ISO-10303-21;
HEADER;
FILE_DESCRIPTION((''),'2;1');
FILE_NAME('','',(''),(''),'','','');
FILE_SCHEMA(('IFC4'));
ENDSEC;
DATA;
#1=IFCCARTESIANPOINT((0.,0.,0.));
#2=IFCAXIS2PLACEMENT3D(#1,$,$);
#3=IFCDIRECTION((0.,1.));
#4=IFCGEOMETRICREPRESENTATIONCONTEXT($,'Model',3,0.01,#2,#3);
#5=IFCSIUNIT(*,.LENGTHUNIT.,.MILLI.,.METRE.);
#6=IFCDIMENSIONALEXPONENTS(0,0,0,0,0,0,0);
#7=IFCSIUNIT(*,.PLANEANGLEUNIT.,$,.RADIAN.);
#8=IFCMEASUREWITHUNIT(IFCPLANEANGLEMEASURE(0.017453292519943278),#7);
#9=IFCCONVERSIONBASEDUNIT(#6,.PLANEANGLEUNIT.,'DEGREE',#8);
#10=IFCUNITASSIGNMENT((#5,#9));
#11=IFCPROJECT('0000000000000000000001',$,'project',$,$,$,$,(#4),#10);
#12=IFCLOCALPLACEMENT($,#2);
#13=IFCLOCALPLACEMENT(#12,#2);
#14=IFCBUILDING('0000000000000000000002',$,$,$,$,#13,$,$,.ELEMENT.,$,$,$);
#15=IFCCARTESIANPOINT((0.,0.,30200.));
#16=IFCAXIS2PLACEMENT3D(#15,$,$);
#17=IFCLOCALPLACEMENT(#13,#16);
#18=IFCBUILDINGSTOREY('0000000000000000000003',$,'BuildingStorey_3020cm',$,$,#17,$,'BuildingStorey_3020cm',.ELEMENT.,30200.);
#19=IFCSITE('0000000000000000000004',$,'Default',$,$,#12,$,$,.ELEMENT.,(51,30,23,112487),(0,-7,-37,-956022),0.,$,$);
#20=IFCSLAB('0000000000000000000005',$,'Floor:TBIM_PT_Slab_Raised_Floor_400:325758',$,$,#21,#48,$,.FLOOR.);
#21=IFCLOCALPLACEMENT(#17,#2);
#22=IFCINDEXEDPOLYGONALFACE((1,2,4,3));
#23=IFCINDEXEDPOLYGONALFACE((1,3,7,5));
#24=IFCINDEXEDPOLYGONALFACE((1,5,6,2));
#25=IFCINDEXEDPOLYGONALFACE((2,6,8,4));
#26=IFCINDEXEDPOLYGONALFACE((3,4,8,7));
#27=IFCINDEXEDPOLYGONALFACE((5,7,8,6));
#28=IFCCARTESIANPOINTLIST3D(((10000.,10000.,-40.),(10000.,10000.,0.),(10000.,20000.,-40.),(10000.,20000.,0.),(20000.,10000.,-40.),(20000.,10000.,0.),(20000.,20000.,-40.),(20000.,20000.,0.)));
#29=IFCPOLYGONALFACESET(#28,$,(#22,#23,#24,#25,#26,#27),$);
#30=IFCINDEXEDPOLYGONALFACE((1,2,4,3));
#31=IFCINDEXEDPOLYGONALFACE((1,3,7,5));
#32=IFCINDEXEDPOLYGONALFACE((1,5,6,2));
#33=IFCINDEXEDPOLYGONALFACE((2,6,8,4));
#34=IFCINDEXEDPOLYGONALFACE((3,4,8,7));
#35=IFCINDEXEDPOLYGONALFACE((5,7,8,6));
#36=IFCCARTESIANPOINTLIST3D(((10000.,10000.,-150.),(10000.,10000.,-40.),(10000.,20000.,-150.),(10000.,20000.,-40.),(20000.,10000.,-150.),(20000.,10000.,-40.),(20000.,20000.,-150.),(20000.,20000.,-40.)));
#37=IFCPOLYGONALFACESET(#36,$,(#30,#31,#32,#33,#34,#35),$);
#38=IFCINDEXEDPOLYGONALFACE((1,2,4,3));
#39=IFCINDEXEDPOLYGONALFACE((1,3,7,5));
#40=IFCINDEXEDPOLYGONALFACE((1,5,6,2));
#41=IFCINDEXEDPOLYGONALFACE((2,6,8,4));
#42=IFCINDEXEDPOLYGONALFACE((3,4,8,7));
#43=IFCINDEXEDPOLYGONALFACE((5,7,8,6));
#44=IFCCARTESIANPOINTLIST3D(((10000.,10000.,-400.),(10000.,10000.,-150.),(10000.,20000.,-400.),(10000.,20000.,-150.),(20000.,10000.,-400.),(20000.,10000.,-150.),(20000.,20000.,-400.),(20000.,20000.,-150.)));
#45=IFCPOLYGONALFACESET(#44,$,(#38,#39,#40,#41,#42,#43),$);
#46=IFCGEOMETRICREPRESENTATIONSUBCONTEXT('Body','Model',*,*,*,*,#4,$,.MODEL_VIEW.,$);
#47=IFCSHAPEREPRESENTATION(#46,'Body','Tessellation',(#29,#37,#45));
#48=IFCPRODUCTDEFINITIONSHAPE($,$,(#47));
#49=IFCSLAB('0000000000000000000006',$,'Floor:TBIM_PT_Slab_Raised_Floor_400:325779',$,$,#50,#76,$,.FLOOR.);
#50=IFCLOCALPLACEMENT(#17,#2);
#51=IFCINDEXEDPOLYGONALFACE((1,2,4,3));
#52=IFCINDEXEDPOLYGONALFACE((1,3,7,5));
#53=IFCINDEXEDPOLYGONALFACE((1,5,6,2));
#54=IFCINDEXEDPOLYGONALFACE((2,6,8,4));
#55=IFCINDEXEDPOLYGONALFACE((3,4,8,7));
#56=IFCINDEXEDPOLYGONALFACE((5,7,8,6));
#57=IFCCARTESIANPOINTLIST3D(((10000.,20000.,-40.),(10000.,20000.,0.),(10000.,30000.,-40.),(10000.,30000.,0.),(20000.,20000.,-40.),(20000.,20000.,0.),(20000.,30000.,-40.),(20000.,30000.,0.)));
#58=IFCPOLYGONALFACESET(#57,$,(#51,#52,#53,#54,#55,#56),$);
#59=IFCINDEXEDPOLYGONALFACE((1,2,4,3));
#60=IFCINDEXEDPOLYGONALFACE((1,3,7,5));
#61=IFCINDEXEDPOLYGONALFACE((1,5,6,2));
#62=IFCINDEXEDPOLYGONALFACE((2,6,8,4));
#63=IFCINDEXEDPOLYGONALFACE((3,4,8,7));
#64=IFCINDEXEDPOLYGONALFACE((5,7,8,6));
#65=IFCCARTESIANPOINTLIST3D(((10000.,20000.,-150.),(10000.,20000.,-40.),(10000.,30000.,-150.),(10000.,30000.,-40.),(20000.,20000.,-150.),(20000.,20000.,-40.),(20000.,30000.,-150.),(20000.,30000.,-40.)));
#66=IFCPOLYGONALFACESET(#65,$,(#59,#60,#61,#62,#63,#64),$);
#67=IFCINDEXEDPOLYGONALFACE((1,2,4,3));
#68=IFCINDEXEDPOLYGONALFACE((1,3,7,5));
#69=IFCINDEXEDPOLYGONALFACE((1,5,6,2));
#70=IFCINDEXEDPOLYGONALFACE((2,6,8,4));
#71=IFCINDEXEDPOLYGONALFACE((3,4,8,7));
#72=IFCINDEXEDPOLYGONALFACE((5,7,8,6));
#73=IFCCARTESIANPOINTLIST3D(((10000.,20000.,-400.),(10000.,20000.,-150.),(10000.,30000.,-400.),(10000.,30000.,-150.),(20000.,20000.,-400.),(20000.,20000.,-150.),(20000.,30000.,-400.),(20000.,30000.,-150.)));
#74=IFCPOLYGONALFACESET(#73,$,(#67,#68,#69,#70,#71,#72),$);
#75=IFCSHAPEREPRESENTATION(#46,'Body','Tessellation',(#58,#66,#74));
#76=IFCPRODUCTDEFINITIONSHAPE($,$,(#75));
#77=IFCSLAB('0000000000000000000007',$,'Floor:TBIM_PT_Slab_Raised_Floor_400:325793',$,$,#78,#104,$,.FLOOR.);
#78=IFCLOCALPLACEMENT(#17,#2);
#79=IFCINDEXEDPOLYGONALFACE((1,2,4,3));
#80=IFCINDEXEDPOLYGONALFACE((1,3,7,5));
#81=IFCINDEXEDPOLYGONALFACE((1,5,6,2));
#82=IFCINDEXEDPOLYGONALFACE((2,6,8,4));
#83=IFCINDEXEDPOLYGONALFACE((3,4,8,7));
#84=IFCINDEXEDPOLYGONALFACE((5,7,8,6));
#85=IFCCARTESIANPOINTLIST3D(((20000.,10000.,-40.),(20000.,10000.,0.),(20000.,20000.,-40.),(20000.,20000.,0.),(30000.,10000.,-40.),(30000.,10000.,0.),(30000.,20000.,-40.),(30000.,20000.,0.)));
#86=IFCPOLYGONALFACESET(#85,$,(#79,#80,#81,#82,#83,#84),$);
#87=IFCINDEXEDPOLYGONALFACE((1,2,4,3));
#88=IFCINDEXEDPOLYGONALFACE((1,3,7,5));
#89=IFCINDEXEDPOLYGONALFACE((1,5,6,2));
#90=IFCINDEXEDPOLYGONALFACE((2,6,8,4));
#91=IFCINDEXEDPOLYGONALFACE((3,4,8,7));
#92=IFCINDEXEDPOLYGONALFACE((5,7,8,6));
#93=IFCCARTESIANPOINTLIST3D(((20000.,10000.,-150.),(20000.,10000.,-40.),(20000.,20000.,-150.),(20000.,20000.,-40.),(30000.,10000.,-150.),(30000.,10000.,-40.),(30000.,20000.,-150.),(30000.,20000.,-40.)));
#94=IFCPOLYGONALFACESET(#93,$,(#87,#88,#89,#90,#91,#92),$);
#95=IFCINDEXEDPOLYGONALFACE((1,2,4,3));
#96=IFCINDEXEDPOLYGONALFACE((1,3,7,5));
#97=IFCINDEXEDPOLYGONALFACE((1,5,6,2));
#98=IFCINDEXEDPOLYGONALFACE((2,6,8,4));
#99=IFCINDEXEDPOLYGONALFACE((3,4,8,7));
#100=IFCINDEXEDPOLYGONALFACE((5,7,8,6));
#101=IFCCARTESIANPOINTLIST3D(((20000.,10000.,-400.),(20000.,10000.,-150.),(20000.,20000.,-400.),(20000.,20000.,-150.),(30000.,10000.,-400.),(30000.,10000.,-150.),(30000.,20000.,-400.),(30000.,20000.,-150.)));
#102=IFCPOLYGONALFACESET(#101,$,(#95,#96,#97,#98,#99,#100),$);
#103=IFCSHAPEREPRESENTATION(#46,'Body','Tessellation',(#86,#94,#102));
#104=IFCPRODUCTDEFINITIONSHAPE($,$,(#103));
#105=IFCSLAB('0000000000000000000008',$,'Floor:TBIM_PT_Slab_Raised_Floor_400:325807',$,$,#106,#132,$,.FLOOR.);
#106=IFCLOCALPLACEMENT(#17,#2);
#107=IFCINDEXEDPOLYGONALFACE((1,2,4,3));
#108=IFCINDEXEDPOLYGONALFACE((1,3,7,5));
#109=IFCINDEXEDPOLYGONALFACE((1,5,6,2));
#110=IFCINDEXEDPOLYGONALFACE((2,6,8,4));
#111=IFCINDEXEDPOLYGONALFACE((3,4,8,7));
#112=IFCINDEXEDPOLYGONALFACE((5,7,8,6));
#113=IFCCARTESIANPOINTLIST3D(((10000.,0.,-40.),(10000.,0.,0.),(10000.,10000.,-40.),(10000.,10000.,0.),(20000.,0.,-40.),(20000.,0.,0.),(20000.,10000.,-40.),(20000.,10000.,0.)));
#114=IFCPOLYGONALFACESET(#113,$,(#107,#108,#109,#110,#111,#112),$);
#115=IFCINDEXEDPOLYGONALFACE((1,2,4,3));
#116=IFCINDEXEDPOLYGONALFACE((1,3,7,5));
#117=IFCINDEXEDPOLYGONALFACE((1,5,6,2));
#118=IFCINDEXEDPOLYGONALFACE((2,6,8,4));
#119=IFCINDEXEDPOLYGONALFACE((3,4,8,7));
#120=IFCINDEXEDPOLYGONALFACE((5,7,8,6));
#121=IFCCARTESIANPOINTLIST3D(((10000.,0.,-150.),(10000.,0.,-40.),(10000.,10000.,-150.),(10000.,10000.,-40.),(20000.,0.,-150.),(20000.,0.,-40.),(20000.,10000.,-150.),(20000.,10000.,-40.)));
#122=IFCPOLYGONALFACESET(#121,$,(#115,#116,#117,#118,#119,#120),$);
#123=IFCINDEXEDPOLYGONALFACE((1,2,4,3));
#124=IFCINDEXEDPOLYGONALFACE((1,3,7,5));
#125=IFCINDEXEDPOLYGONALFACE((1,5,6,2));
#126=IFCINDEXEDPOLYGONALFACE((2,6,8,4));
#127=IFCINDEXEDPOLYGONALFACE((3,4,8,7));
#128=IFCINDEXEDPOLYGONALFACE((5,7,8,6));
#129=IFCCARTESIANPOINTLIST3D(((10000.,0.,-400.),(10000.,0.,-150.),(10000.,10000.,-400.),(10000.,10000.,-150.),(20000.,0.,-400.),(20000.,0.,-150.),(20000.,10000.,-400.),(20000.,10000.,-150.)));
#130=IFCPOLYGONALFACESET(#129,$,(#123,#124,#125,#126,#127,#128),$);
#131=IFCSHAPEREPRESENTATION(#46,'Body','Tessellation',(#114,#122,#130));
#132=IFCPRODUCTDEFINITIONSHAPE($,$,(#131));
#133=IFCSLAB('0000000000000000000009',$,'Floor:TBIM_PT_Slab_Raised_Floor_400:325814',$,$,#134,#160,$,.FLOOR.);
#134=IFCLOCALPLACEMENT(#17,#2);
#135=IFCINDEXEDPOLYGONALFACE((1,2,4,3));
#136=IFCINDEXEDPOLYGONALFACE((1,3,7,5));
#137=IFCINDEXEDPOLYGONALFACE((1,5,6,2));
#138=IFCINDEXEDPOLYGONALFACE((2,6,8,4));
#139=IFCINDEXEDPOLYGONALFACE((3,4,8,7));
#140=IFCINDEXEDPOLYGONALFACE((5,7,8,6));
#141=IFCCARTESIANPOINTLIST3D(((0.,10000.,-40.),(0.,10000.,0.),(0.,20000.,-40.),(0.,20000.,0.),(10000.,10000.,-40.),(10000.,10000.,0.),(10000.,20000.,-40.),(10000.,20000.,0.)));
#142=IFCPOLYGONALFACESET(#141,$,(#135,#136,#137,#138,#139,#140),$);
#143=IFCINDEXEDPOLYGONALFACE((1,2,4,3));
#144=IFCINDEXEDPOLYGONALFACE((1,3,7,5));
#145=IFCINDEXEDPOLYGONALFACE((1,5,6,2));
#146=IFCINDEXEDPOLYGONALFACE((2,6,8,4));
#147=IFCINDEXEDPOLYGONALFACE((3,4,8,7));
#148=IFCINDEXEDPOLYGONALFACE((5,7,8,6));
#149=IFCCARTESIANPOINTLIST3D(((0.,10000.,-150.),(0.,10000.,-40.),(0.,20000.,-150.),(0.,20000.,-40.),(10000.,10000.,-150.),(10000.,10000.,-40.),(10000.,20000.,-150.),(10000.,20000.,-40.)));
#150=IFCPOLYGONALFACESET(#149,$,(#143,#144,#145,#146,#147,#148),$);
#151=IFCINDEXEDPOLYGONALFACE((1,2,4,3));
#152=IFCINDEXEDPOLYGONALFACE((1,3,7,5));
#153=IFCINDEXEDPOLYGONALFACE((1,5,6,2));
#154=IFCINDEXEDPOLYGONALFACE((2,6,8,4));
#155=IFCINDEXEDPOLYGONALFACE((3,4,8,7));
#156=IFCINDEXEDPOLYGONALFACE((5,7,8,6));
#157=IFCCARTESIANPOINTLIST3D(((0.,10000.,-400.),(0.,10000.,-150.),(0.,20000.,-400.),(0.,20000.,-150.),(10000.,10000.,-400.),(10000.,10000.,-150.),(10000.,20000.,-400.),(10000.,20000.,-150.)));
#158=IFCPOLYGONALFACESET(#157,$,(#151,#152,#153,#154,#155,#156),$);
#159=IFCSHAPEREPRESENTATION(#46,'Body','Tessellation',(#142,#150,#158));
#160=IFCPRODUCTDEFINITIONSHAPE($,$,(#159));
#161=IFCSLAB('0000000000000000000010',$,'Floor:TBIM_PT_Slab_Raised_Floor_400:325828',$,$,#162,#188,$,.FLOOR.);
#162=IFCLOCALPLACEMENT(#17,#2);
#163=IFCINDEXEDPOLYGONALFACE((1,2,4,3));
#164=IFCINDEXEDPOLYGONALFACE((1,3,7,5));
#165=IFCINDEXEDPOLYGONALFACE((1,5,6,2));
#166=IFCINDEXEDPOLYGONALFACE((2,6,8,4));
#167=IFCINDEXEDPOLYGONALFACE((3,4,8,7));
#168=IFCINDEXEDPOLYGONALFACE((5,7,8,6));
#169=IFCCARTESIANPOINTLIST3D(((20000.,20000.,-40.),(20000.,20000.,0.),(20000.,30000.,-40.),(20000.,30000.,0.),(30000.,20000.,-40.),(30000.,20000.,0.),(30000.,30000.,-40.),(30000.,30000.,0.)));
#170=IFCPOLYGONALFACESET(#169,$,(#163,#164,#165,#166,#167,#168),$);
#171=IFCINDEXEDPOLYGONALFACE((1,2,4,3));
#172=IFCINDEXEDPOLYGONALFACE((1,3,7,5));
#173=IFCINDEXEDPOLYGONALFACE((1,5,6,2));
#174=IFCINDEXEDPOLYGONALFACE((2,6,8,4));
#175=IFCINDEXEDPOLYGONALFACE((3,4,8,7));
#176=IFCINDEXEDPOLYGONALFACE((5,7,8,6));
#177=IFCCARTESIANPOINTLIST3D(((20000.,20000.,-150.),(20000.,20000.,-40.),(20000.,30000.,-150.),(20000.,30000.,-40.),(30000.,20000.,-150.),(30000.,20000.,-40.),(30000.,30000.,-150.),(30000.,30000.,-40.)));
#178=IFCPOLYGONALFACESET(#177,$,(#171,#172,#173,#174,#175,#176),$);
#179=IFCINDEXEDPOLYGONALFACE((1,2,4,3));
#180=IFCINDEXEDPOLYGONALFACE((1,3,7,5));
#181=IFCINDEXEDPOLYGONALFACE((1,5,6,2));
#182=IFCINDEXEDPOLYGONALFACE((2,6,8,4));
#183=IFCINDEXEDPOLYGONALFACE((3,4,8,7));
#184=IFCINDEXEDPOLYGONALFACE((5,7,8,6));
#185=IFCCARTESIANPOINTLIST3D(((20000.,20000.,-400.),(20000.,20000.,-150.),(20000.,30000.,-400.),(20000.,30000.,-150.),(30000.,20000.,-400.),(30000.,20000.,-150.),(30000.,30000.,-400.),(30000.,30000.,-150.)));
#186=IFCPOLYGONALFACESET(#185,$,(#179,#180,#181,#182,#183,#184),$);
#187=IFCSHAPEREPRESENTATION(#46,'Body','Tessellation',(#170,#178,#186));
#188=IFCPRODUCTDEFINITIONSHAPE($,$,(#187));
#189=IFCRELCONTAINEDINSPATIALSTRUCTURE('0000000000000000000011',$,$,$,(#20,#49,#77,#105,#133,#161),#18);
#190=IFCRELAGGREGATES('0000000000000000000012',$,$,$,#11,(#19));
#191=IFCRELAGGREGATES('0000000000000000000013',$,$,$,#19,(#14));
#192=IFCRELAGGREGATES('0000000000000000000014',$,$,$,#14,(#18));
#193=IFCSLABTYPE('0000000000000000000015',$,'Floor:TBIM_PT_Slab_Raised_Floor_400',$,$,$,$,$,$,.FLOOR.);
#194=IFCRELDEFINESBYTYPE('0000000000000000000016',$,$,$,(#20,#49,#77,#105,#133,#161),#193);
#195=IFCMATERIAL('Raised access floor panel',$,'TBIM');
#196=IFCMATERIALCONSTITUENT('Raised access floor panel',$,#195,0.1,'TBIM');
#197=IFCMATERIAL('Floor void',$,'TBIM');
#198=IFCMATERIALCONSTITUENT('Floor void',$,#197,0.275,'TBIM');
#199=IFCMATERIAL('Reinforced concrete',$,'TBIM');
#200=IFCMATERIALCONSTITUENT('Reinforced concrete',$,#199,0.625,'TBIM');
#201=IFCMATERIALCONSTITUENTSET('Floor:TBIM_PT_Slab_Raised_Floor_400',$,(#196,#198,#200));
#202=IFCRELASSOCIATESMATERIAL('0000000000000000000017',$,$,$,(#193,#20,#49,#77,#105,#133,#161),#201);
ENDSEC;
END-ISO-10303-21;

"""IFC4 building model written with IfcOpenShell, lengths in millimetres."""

from ifc_helpers import new_model, entity, si_unit, converted_unit, direction, frame, origin, place, context, subcontext, project, spatial, indexed_curve, outline, extrude, material, constituent, constituent_set, type_object, element, save


model = new_model("IFC4")

# Units and contexts
model_context = context("Model", 3, precision=0.01, world=origin(), true_north=direction((0.0, 1.0)))
body_context = subcontext(model_context, "Body", "Model", "MODEL_VIEW")
ifc_project = project(units=[si_unit("LENGTHUNIT", "METRE", prefix="MILLI"), converted_unit("PLANEANGLEUNIT", "DEGREE", entity("IfcPlaneAngleMeasure", 0.017453292519943278), si_unit("PLANEANGLEUNIT", "RADIAN"), dimensions=[0, 0, 0, 0, 0, 0, 0])], contexts=[model_context])

# Site, building, storey
site_placement = place(None, origin())
site = spatial("IfcSite", under=ifc_project, at=site_placement, Name="Default", CompositionType="ELEMENT", RefLatitude=(51, 30, 23, 112487), RefLongitude=(0, -7, -37, -956022), RefElevation=0.0)
building_placement = place(site_placement, origin())
building = spatial("IfcBuilding", under=site, at=building_placement, CompositionType="ELEMENT")
storey_placement = place(building_placement, frame((0.0, 0.0, 30200.0)))
storey = spatial("IfcBuildingStorey", under=building, at=storey_placement, Name="BuildingStorey_3020cm", LongName="BuildingStorey_3020cm", CompositionType="ELEMENT", Elevation=30200.0)

# Slabs
ifc_material_1 = material(Name="Raised access floor panel", Category="TBIM")
ifc_constituent_1 = constituent(ifc_material_1, Name="Raised access floor panel", Category="TBIM", fraction=0.1)
ifc_material_2 = material(Name="Floor void", Category="TBIM")
ifc_constituent_2 = constituent(ifc_material_2, Name="Floor void", Category="TBIM", fraction=0.275)
ifc_material_3 = material(Name="Reinforced concrete", Category="TBIM")
ifc_constituent_3 = constituent(ifc_material_3, Name="Reinforced concrete", Category="TBIM", fraction=0.625)
ifc_constituent_set_1 = constituent_set(constituents=[ifc_constituent_1, ifc_constituent_2, ifc_constituent_3], Name="Floor:TBIM_PT_Slab_Raised_Floor_400")
slab_type = type_object("IfcSlabType", Name="Floor:TBIM_PT_Slab_Raised_Floor_400", PredefinedType="FLOOR", material=ifc_constituent_set_1)
slab_1_placement = place(storey_placement, origin())
element("IfcSlab", 1, at=slab_1_placement, inside=storey, type_object=slab_type, material=ifc_constituent_set_1, Name="Floor:TBIM_PT_Slab_Raised_Floor_400:325758", PredefinedType="FLOOR", context=body_context, shape_type="SweptSolid", body=[
    extrude(outline(indexed_curve([(-5000.0, -5000.0), (5000.0, -5000.0), (5000.0, 5000.0), (-5000.0, 5000.0), (-5000.0, -5000.0)], self_intersect=False)), frame((15000.0, 15000.0, -40.0), z_axis=(0.0, 0.0, 1.0), x_axis=(-1.0, 0.0, 0.0)), (0.0, 0.0, 1.0), 40.0),
    extrude(outline(indexed_curve([(-5000.0, -5000.0), (5000.0, -5000.0), (5000.0, 5000.0), (-5000.0, 5000.0), (-5000.0, -5000.0)], self_intersect=False)), frame((15000.0, 15000.0, -150.0), z_axis=(0.0, 0.0, 1.0), x_axis=(-1.0, 0.0, 0.0)), (0.0, 0.0, 1.0), 110.0),
    extrude(outline(indexed_curve([(-5000.0, -5000.0), (5000.0, -5000.0), (5000.0, 5000.0), (-5000.0, 5000.0), (-5000.0, -5000.0)], self_intersect=False)), frame((15000.0, 15000.0, -400.0), z_axis=(0.0, 0.0, 1.0), x_axis=(-1.0, 0.0, 0.0)), (0.0, 0.0, 1.0), 250.0),
])
slab_2_placement = place(storey_placement, origin())
element("IfcSlab", 2, at=slab_2_placement, inside=storey, type_object=slab_type, material=ifc_constituent_set_1, Name="Floor:TBIM_PT_Slab_Raised_Floor_400:325779", PredefinedType="FLOOR", context=body_context, shape_type="SweptSolid", body=[
    extrude(outline(indexed_curve([(-5000.0, -5000.0), (5000.0, -5000.0), (5000.0, 5000.0), (-5000.0, 5000.0), (-5000.0, -5000.0)], self_intersect=False)), frame((15000.0, 25000.0, -40.0), z_axis=(0.0, 0.0, 1.0), x_axis=(-1.0, 0.0, 0.0)), (0.0, 0.0, 1.0), 40.0),
    extrude(outline(indexed_curve([(-5000.0, -5000.0), (5000.0, -5000.0), (5000.0, 5000.0), (-5000.0, 5000.0), (-5000.0, -5000.0)], self_intersect=False)), frame((15000.0, 25000.0, -150.0), z_axis=(0.0, 0.0, 1.0), x_axis=(-1.0, 0.0, 0.0)), (0.0, 0.0, 1.0), 110.0),
    extrude(outline(indexed_curve([(-5000.0, -5000.0), (5000.0, -5000.0), (5000.0, 5000.0), (-5000.0, 5000.0), (-5000.0, -5000.0)], self_intersect=False)), frame((15000.0, 25000.0, -400.0), z_axis=(0.0, 0.0, 1.0), x_axis=(-1.0, 0.0, 0.0)), (0.0, 0.0, 1.0), 250.0),
])
slab_3_placement = place(storey_placement, origin())
element("IfcSlab", 3, at=slab_3_placement, inside=storey, type_object=slab_type, material=ifc_constituent_set_1, Name="Floor:TBIM_PT_Slab_Raised_Floor_400:325793", PredefinedType="FLOOR", context=body_context, shape_type="SweptSolid", body=[
    extrude(outline(indexed_curve([(-5000.0, -5000.0), (5000.0, -5000.0), (5000.0, 5000.0), (-5000.0, 5000.0), (-5000.0, -5000.0)], self_intersect=False)), frame((25000.0, 15000.0, -40.0), z_axis=(0.0, 0.0, 1.0), x_axis=(-1.0, 0.0, 0.0)), (0.0, 0.0, 1.0), 40.0),
    extrude(outline(indexed_curve([(-5000.0, -5000.0), (5000.0, -5000.0), (5000.0, 5000.0), (-5000.0, 5000.0), (-5000.0, -5000.0)], self_intersect=False)), frame((25000.0, 15000.0, -150.0), z_axis=(0.0, 0.0, 1.0), x_axis=(-1.0, 0.0, 0.0)), (0.0, 0.0, 1.0), 110.0),
    extrude(outline(indexed_curve([(-5000.0, -5000.0), (5000.0, -5000.0), (5000.0, 5000.0), (-5000.0, 5000.0), (-5000.0, -5000.0)], self_intersect=False)), frame((25000.0, 15000.0, -400.0), z_axis=(0.0, 0.0, 1.0), x_axis=(-1.0, 0.0, 0.0)), (0.0, 0.0, 1.0), 250.0),
])
slab_4_placement = place(storey_placement, origin())
element("IfcSlab", 4, at=slab_4_placement, inside=storey, type_object=slab_type, material=ifc_constituent_set_1, Name="Floor:TBIM_PT_Slab_Raised_Floor_400:325807", PredefinedType="FLOOR", context=body_context, shape_type="SweptSolid", body=[
    extrude(outline(indexed_curve([(-5000.0, -5000.0), (5000.0, -5000.0), (5000.0, 5000.0), (-5000.0, 5000.0), (-5000.0, -5000.0)], self_intersect=False)), frame((15000.0, 5000.0, -40.0), z_axis=(0.0, 0.0, 1.0), x_axis=(0.0, 1.0, 0.0)), (0.0, 0.0, 1.0), 40.0),
    extrude(outline(indexed_curve([(-5000.0, -5000.0), (5000.0, -5000.0), (5000.0, 5000.0), (-5000.0, 5000.0), (-5000.0, -5000.0)], self_intersect=False)), frame((15000.0, 5000.0, -150.0), z_axis=(0.0, 0.0, 1.0), x_axis=(0.0, 1.0, 0.0)), (0.0, 0.0, 1.0), 110.0),
    extrude(outline(indexed_curve([(-5000.0, -5000.0), (5000.0, -5000.0), (5000.0, 5000.0), (-5000.0, 5000.0), (-5000.0, -5000.0)], self_intersect=False)), frame((15000.0, 5000.0, -400.0), z_axis=(0.0, 0.0, 1.0), x_axis=(0.0, 1.0, 0.0)), (0.0, 0.0, 1.0), 250.0),
])
slab_5_placement = place(storey_placement, origin())
element("IfcSlab", 5, at=slab_5_placement, inside=storey, type_object=slab_type, material=ifc_constituent_set_1, Name="Floor:TBIM_PT_Slab_Raised_Floor_400:325814", PredefinedType="FLOOR", context=body_context, shape_type="SweptSolid", body=[
    extrude(outline(indexed_curve([(-5000.0, -5000.0), (5000.0, -5000.0), (5000.0, 5000.0), (-5000.0, 5000.0), (-5000.0, -5000.0)], self_intersect=False)), frame((5000.0, 15000.0, -40.0), z_axis=(0.0, 0.0, 1.0), x_axis=(0.0, 1.0, 0.0)), (0.0, 0.0, 1.0), 40.0),
    extrude(outline(indexed_curve([(-5000.0, -5000.0), (5000.0, -5000.0), (5000.0, 5000.0), (-5000.0, 5000.0), (-5000.0, -5000.0)], self_intersect=False)), frame((5000.0, 15000.0, -150.0), z_axis=(0.0, 0.0, 1.0), x_axis=(0.0, 1.0, 0.0)), (0.0, 0.0, 1.0), 110.0),
    extrude(outline(indexed_curve([(-5000.0, -5000.0), (5000.0, -5000.0), (5000.0, 5000.0), (-5000.0, 5000.0), (-5000.0, -5000.0)], self_intersect=False)), frame((5000.0, 15000.0, -400.0), z_axis=(0.0, 0.0, 1.0), x_axis=(0.0, 1.0, 0.0)), (0.0, 0.0, 1.0), 250.0),
])
slab_6_placement = place(storey_placement, origin())
element("IfcSlab", 6, at=slab_6_placement, inside=storey, type_object=slab_type, material=ifc_constituent_set_1, Name="Floor:TBIM_PT_Slab_Raised_Floor_400:325828", PredefinedType="FLOOR", context=body_context, shape_type="SweptSolid", body=[
    extrude(outline(indexed_curve([(-5000.0, -5000.0), (5000.0, -5000.0), (5000.0, 5000.0), (-5000.0, 5000.0), (-5000.0, -5000.0)], self_intersect=False)), frame((25000.0, 25000.0, -40.0), z_axis=(0.0, 0.0, 1.0), x_axis=(-1.0, 0.0, 0.0)), (0.0, 0.0, 1.0), 40.0),
    extrude(outline(indexed_curve([(-5000.0, -5000.0), (5000.0, -5000.0), (5000.0, 5000.0), (-5000.0, 5000.0), (-5000.0, -5000.0)], self_intersect=False)), frame((25000.0, 25000.0, -150.0), z_axis=(0.0, 0.0, 1.0), x_axis=(-1.0, 0.0, 0.0)), (0.0, 0.0, 1.0), 110.0),
    extrude(outline(indexed_curve([(-5000.0, -5000.0), (5000.0, -5000.0), (5000.0, 5000.0), (-5000.0, 5000.0), (-5000.0, -5000.0)], self_intersect=False)), frame((25000.0, 25000.0, -400.0), z_axis=(0.0, 0.0, 1.0), x_axis=(-1.0, 0.0, 0.0)), (0.0, 0.0, 1.0), 250.0),
])

save(model, "model.ifc")
